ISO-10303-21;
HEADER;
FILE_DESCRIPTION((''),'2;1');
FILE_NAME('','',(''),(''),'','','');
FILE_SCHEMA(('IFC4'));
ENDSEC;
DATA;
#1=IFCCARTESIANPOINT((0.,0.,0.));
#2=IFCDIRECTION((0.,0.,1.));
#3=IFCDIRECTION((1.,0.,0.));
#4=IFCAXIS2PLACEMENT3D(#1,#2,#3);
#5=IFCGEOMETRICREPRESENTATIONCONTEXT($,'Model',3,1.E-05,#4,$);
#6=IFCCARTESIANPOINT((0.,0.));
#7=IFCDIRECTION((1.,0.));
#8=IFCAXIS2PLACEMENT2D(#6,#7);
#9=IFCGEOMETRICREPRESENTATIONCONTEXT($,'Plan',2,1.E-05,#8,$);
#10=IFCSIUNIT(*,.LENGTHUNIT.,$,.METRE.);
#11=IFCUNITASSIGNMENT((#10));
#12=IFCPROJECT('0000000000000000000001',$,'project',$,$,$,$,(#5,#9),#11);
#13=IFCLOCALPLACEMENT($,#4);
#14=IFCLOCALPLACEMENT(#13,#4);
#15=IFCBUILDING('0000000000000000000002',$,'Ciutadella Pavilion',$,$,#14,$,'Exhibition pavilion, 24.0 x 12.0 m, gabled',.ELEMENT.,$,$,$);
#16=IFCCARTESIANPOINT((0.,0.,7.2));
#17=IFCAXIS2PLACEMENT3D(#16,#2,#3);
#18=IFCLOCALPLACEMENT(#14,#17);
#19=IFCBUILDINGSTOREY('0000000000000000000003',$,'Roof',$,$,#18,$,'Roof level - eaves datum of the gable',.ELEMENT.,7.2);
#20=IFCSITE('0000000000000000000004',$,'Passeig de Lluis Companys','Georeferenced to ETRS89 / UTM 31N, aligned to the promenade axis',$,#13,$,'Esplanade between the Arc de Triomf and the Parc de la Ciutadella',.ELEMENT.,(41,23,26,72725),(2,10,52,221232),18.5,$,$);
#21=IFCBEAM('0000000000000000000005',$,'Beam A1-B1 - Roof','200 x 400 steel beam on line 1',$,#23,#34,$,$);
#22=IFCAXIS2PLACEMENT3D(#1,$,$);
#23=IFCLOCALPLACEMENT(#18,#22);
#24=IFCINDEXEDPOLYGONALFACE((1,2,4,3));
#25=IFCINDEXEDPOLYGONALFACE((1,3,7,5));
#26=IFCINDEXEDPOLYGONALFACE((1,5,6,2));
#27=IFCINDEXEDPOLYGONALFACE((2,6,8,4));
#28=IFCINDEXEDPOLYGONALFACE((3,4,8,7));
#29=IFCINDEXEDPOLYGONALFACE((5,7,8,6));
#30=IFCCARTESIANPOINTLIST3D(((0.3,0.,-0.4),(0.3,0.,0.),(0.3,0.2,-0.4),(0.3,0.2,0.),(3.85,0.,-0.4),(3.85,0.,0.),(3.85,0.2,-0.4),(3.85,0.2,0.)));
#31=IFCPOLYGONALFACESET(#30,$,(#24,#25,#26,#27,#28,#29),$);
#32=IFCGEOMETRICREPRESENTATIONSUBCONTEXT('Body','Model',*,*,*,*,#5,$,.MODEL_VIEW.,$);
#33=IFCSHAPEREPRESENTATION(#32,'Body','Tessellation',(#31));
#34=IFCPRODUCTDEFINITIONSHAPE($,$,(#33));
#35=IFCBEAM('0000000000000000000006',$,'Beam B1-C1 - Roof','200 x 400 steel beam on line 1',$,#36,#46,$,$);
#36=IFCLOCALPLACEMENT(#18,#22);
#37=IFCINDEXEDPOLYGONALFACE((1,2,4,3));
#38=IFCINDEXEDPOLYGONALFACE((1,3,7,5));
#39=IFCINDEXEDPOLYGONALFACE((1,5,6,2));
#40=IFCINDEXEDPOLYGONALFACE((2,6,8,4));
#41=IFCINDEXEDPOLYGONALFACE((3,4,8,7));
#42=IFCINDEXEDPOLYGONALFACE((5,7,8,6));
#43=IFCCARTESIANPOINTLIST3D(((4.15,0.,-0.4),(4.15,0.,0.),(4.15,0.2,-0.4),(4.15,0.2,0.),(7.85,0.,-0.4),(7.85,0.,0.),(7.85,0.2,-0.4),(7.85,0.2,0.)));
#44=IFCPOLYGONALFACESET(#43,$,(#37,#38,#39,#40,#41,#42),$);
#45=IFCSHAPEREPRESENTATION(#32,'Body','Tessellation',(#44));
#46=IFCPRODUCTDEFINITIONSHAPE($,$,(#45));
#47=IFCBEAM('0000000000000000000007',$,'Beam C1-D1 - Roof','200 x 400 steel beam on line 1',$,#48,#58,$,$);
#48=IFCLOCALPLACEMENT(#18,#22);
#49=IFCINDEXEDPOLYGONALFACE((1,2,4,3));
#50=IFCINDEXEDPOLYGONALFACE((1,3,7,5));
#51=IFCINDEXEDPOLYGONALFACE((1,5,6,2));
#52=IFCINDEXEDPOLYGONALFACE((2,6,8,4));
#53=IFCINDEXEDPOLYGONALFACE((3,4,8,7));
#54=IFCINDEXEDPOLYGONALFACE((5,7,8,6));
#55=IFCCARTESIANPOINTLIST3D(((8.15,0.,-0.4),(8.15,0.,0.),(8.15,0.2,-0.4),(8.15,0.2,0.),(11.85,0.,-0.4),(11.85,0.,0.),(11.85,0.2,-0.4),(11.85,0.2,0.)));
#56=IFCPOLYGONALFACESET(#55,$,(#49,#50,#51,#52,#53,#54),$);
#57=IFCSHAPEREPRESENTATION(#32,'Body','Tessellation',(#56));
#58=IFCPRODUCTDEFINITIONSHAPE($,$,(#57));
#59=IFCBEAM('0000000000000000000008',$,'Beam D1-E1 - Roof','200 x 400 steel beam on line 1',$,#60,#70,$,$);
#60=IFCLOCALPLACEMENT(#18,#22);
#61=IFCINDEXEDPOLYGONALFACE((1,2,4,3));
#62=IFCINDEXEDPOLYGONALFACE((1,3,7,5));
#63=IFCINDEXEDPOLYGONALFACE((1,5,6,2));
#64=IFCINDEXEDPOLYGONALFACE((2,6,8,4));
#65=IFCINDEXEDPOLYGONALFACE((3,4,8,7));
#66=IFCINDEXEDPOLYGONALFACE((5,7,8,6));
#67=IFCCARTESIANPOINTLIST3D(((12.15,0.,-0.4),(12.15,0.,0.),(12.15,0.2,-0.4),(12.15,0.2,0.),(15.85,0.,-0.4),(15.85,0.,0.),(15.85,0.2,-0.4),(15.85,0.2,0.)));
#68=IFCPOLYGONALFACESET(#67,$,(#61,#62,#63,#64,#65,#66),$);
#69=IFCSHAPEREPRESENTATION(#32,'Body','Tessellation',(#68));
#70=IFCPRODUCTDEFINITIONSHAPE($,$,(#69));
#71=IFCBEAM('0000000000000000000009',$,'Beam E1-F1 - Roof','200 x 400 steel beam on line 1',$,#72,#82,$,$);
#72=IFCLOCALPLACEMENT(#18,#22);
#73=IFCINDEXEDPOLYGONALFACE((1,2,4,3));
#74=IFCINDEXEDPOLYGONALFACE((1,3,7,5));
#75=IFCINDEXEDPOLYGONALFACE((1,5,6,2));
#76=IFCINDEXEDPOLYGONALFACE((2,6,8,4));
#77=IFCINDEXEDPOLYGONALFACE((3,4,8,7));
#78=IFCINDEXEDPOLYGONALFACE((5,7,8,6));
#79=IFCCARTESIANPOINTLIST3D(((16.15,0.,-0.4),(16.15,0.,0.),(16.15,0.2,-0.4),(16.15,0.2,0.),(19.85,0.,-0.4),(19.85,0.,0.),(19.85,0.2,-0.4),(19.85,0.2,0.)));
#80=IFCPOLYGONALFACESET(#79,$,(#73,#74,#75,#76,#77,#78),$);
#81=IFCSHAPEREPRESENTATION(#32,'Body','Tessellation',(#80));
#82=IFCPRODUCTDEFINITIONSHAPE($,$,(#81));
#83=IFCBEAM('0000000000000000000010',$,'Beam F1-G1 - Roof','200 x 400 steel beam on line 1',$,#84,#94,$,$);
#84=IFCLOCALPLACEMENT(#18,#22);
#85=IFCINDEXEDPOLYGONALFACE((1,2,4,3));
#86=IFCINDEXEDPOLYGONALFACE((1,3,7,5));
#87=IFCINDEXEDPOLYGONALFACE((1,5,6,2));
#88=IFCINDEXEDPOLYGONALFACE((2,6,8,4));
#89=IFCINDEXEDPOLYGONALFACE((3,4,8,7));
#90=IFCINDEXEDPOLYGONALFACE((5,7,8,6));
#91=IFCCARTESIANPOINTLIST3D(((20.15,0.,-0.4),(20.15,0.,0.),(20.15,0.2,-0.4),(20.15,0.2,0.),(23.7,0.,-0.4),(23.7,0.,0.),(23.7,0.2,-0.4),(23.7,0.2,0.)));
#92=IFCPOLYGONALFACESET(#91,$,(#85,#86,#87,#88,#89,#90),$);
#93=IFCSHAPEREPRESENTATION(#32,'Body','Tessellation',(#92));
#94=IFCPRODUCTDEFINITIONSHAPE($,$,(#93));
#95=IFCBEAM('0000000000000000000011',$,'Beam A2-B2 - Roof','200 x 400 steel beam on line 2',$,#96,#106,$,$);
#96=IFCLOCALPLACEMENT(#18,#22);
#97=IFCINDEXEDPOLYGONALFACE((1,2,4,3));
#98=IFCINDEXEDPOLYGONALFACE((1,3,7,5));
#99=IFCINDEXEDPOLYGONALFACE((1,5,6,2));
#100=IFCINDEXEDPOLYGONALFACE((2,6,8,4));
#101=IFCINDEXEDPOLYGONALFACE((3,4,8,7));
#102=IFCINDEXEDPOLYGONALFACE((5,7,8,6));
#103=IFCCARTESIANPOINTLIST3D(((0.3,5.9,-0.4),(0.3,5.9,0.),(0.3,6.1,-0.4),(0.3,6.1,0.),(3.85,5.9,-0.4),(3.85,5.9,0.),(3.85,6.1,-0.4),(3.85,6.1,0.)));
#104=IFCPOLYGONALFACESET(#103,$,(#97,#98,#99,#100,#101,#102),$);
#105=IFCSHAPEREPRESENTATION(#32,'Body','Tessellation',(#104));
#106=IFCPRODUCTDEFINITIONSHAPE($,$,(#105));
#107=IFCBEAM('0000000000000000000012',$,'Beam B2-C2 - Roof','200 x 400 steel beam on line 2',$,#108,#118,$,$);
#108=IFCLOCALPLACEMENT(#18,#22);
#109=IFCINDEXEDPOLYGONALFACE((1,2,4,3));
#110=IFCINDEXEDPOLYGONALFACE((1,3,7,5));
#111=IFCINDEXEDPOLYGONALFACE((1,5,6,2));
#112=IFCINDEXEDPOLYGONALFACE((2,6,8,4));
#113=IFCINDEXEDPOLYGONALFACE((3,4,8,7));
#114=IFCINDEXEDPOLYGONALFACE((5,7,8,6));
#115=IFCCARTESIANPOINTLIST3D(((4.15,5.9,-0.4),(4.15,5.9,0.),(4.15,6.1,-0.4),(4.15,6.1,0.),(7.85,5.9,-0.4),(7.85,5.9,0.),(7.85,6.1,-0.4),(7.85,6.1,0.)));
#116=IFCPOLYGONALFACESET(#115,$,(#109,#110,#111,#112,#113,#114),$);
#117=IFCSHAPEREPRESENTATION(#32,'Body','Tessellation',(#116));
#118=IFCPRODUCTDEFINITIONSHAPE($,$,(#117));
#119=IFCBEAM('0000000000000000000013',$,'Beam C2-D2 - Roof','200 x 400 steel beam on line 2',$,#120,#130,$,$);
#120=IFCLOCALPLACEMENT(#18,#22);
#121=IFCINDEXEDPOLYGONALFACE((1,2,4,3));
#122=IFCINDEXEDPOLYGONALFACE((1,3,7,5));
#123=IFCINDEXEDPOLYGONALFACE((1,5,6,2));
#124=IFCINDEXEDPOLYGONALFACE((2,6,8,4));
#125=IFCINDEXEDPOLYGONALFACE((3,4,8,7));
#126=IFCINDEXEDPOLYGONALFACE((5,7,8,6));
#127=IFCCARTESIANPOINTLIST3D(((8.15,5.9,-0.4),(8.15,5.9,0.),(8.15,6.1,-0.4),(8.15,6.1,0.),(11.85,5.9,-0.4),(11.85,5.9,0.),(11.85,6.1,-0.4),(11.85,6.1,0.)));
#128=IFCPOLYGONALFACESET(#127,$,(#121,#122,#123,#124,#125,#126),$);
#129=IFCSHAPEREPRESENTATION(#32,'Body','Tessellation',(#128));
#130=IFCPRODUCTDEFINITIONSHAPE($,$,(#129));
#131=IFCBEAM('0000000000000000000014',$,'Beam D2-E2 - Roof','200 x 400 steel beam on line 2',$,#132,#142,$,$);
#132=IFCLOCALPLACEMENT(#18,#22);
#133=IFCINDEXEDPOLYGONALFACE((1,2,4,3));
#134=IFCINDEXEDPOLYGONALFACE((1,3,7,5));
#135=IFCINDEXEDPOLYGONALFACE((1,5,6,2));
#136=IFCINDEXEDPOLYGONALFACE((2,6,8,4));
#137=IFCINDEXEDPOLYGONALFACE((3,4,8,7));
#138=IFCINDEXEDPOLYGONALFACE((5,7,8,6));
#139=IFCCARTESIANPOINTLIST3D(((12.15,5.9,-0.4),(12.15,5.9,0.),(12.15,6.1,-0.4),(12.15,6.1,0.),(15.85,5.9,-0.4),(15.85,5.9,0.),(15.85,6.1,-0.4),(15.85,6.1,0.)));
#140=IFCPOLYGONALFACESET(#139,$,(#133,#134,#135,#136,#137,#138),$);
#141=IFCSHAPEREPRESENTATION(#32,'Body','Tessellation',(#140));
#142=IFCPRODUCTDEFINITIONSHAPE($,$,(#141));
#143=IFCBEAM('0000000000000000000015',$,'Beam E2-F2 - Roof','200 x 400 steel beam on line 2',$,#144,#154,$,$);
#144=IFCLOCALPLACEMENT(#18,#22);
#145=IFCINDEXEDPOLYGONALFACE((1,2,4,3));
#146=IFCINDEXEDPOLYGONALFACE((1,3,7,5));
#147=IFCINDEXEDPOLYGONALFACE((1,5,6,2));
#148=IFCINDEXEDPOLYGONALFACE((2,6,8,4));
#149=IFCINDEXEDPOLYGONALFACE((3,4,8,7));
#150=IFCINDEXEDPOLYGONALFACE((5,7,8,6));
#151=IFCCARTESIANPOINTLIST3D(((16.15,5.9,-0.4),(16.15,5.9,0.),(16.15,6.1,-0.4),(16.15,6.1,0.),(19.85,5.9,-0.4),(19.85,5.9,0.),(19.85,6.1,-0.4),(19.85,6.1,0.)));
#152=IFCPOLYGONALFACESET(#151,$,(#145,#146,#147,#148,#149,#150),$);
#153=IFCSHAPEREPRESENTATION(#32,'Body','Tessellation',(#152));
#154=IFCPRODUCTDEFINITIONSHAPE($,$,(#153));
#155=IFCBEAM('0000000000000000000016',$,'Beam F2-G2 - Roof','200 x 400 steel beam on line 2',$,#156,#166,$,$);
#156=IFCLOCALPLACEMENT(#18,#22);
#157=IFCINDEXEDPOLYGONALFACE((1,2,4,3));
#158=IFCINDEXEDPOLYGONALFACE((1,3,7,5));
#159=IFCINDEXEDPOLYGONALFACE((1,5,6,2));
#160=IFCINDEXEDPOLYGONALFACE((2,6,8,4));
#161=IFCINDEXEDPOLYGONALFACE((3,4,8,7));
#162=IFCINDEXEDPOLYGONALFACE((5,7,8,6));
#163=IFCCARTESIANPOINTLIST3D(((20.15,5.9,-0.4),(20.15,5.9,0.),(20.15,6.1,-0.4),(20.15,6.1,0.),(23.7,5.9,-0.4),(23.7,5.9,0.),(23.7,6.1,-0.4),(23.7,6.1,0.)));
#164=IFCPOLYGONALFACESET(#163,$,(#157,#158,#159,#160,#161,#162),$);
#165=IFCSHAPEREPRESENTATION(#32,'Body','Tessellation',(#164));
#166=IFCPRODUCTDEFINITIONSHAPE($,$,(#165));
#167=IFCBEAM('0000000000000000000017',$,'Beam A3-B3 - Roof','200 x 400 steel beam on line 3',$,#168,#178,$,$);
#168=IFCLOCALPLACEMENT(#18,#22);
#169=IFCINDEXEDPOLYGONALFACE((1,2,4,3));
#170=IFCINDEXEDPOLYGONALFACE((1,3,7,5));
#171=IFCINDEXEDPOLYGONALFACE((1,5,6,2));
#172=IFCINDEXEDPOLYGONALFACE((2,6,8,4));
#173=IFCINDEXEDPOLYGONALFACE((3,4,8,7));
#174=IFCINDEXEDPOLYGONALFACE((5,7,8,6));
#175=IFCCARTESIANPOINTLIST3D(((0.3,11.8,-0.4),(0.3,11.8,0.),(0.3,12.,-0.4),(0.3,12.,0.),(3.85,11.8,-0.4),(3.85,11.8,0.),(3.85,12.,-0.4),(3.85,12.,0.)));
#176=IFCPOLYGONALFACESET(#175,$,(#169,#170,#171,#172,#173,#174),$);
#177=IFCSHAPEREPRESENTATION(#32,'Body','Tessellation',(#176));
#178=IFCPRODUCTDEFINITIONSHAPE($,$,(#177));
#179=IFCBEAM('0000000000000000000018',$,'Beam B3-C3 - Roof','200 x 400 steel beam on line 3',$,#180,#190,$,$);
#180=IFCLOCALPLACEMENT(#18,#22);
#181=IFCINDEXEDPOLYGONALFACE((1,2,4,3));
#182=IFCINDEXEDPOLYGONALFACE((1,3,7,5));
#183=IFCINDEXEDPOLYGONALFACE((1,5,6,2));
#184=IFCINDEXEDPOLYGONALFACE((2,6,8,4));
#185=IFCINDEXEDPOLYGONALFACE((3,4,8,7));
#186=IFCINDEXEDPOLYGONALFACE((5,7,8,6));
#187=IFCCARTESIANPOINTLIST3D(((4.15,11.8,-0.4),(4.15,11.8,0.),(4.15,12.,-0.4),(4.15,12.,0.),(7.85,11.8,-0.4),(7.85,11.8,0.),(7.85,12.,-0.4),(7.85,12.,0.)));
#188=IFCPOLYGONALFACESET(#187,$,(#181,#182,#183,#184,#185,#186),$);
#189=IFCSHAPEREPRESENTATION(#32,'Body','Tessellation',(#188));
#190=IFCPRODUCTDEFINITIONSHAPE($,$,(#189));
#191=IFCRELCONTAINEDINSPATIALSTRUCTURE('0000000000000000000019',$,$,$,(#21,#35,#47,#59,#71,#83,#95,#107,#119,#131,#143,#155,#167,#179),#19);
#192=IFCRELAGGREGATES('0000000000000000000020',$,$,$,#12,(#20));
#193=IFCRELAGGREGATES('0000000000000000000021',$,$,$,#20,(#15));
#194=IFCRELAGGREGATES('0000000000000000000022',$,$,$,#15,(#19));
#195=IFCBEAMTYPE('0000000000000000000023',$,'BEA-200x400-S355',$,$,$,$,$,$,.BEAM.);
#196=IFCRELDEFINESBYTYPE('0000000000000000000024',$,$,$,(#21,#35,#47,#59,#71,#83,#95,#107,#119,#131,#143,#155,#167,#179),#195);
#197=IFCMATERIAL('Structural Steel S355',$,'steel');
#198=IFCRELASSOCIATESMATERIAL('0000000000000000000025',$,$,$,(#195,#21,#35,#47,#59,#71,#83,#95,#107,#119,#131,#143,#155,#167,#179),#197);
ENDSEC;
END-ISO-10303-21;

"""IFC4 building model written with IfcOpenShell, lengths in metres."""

from ifc_helpers import new_model, si_unit, frame, origin_with_axes, origin_2d_with_axis, place, context, subcontext, project, spatial, line, indexed_curve, rectangle, outline, extrude, material, material_profile, profile_set, profile_usage, type_object, element, save


model = new_model("IFC4")

# Units and contexts
model_context = context("Model", 3, precision=1e-05, world=origin_with_axes())
plan_context = context("Plan", 2, precision=1e-05, world=origin_2d_with_axis())
body_context = subcontext(model_context, "Body", "Model", "MODEL_VIEW")
ifc_project = project(units=[si_unit("LENGTHUNIT", "METRE")], contexts=[model_context, plan_context])

# Site, building, storey
site_placement = place(None, origin_with_axes())
site = spatial("IfcSite", under=ifc_project, at=site_placement, Name="Passeig de Lluis Companys", Description="Georeferenced to ETRS89 / UTM 31N, aligned to the promenade axis", LongName="Esplanade between the Arc de Triomf and the Parc de la Ciutadella", CompositionType="ELEMENT", RefLatitude=(41, 23, 26, 72725), RefLongitude=(2, 10, 52, 221232), RefElevation=18.5)
building_placement = place(site_placement, origin_with_axes())
building = spatial("IfcBuilding", under=site, at=building_placement, Name="Ciutadella Pavilion", LongName="Exhibition pavilion, 24.0 x 12.0 m, gabled", CompositionType="ELEMENT")
storey_placement = place(building_placement, frame((0.0, 0.0, 7.2), z_axis=(0.0, 0.0, 1.0), x_axis=(1.0, 0.0, 0.0)))
storey = spatial("IfcBuildingStorey", under=building, at=storey_placement, Name="Roof", LongName="Roof level - eaves datum of the gable", CompositionType="ELEMENT", Elevation=7.2)

# Beams
ifc_material_1 = material(Name="Structural Steel S355", Category="steel")
ifc_material_profile = material_profile(ifc_material_1, rectangle(XDim=0.2, YDim=0.4))
ifc_profile_set = profile_set([ifc_material_profile], Name="BEA-200x400-S355")
ifc_profile_usage_1 = profile_usage(ifc_profile_set)
beam_type = type_object("IfcBeamType", Name="BEA-200x400-S355", PredefinedType="BEAM", material=ifc_profile_set)
beam_1_placement = place(storey_placement, frame((0.3, 0.0, -0.4), z_axis=(1.0, 0.0, 0.0), x_axis=(0.0, 1.0, 0.0)))
element("IfcBeam", 1, at=beam_1_placement, inside=storey, type_object=beam_type, material=ifc_profile_usage_1, Name="Beam A1-B1 - Roof", Description="200 x 400 steel beam on line 1", context=body_context, shape_type="SweptSolid", body=[
    extrude(outline(indexed_curve([(0.0, 0.0), (0.2, 0.0), (0.2, 0.4), (0.0, 0.4)], segments=[line(1, 2, 3, 4, 1)])), origin_with_axes(), (0.0, 0.0, 1.0), 3.55),
])
ifc_profile_usage_2 = profile_usage(ifc_profile_set)
beam_2_placement = place(storey_placement, frame((4.15, 0.0, -0.4), z_axis=(1.0, 0.0, 0.0), x_axis=(0.0, 1.0, 0.0)))
element("IfcBeam", 2, at=beam_2_placement, inside=storey, type_object=beam_type, material=ifc_profile_usage_2, Name="Beam B1-C1 - Roof", Description="200 x 400 steel beam on line 1", context=body_context, shape_type="SweptSolid", body=[
    extrude(outline(indexed_curve([(0.0, 0.0), (0.2, 0.0), (0.2, 0.4), (0.0, 0.4)], segments=[line(1, 2, 3, 4, 1)])), origin_with_axes(), (0.0, 0.0, 1.0), 3.7),
])
ifc_profile_usage_3 = profile_usage(ifc_profile_set)
beam_3_placement = place(storey_placement, frame((8.15, 0.0, -0.4), z_axis=(1.0, 0.0, 0.0), x_axis=(0.0, 1.0, 0.0)))
element("IfcBeam", 3, at=beam_3_placement, inside=storey, type_object=beam_type, material=ifc_profile_usage_3, Name="Beam C1-D1 - Roof", Description="200 x 400 steel beam on line 1", context=body_context, shape_type="SweptSolid", body=[
    extrude(outline(indexed_curve([(0.0, 0.0), (0.2, 0.0), (0.2, 0.4), (0.0, 0.4)], segments=[line(1, 2, 3, 4, 1)])), origin_with_axes(), (0.0, 0.0, 1.0), 3.7),
])
ifc_profile_usage_4 = profile_usage(ifc_profile_set)
beam_4_placement = place(storey_placement, frame((12.15, 0.0, -0.4), z_axis=(1.0, 0.0, 0.0), x_axis=(0.0, 1.0, 0.0)))
element("IfcBeam", 4, at=beam_4_placement, inside=storey, type_object=beam_type, material=ifc_profile_usage_4, Name="Beam D1-E1 - Roof", Description="200 x 400 steel beam on line 1", context=body_context, shape_type="SweptSolid", body=[
    extrude(outline(indexed_curve([(0.0, 0.0), (0.2, 0.0), (0.2, 0.4), (0.0, 0.4)], segments=[line(1, 2, 3, 4, 1)])), origin_with_axes(), (0.0, 0.0, 1.0), 3.7),
])
ifc_profile_usage_5 = profile_usage(ifc_profile_set)
beam_5_placement = place(storey_placement, frame((16.15, 0.0, -0.4), z_axis=(1.0, 0.0, 0.0), x_axis=(0.0, 1.0, 0.0)))
element("IfcBeam", 5, at=beam_5_placement, inside=storey, type_object=beam_type, material=ifc_profile_usage_5, Name="Beam E1-F1 - Roof", Description="200 x 400 steel beam on line 1", context=body_context, shape_type="SweptSolid", body=[
    extrude(outline(indexed_curve([(0.0, 0.0), (0.2, 0.0), (0.2, 0.4), (0.0, 0.4)], segments=[line(1, 2, 3, 4, 1)])), origin_with_axes(), (0.0, 0.0, 1.0), 3.7),
])
ifc_profile_usage_6 = profile_usage(ifc_profile_set)
beam_6_placement = place(storey_placement, frame((20.15, 0.0, -0.4), z_axis=(1.0, 0.0, 0.0), x_axis=(0.0, 1.0, 0.0)))
element("IfcBeam", 6, at=beam_6_placement, inside=storey, type_object=beam_type, material=ifc_profile_usage_6, Name="Beam F1-G1 - Roof", Description="200 x 400 steel beam on line 1", context=body_context, shape_type="SweptSolid", body=[
    extrude(outline(indexed_curve([(0.0, 0.0), (0.2, 0.0), (0.2, 0.4), (0.0, 0.4)], segments=[line(1, 2, 3, 4, 1)])), origin_with_axes(), (0.0, 0.0, 1.0), 3.55),
])
ifc_profile_usage_7 = profile_usage(ifc_profile_set)
beam_7_placement = place(storey_placement, frame((0.3, 5.9, -0.4), z_axis=(1.0, 0.0, 0.0), x_axis=(0.0, 1.0, 0.0)))
element("IfcBeam", 7, at=beam_7_placement, inside=storey, type_object=beam_type, material=ifc_profile_usage_7, Name="Beam A2-B2 - Roof", Description="200 x 400 steel beam on line 2", context=body_context, shape_type="SweptSolid", body=[
    extrude(outline(indexed_curve([(0.0, 0.0), (0.2, 0.0), (0.2, 0.4), (0.0, 0.4)], segments=[line(1, 2, 3, 4, 1)])), origin_with_axes(), (0.0, 0.0, 1.0), 3.55),
])
ifc_profile_usage_8 = profile_usage(ifc_profile_set)
beam_8_placement = place(storey_placement, frame((4.15, 5.9, -0.4), z_axis=(1.0, 0.0, 0.0), x_axis=(0.0, 1.0, 0.0)))
element("IfcBeam", 8, at=beam_8_placement, inside=storey, type_object=beam_type, material=ifc_profile_usage_8, Name="Beam B2-C2 - Roof", Description="200 x 400 steel beam on line 2", context=body_context, shape_type="SweptSolid", body=[
    extrude(outline(indexed_curve([(0.0, 0.0), (0.2, 0.0), (0.2, 0.4), (0.0, 0.4)], segments=[line(1, 2, 3, 4, 1)])), origin_with_axes(), (0.0, 0.0, 1.0), 3.7),
])
ifc_profile_usage_9 = profile_usage(ifc_profile_set)
beam_9_placement = place(storey_placement, frame((8.15, 5.9, -0.4), z_axis=(1.0, 0.0, 0.0), x_axis=(0.0, 1.0, 0.0)))
element("IfcBeam", 9, at=beam_9_placement, inside=storey, type_object=beam_type, material=ifc_profile_usage_9, Name="Beam C2-D2 - Roof", Description="200 x 400 steel beam on line 2", context=body_context, shape_type="SweptSolid", body=[
    extrude(outline(indexed_curve([(0.0, 0.0), (0.2, 0.0), (0.2, 0.4), (0.0, 0.4)], segments=[line(1, 2, 3, 4, 1)])), origin_with_axes(), (0.0, 0.0, 1.0), 3.7),
])
ifc_profile_usage_10 = profile_usage(ifc_profile_set)
beam_10_placement = place(storey_placement, frame((12.15, 5.9, -0.4), z_axis=(1.0, 0.0, 0.0), x_axis=(0.0, 1.0, 0.0)))
element("IfcBeam", 10, at=beam_10_placement, inside=storey, type_object=beam_type, material=ifc_profile_usage_10, Name="Beam D2-E2 - Roof", Description="200 x 400 steel beam on line 2", context=body_context, shape_type="SweptSolid", body=[
    extrude(outline(indexed_curve([(0.0, 0.0), (0.2, 0.0), (0.2, 0.4), (0.0, 0.4)], segments=[line(1, 2, 3, 4, 1)])), origin_with_axes(), (0.0, 0.0, 1.0), 3.7),
])
ifc_profile_usage_11 = profile_usage(ifc_profile_set)
beam_11_placement = place(storey_placement, frame((16.15, 5.9, -0.4), z_axis=(1.0, 0.0, 0.0), x_axis=(0.0, 1.0, 0.0)))
element("IfcBeam", 11, at=beam_11_placement, inside=storey, type_object=beam_type, material=ifc_profile_usage_11, Name="Beam E2-F2 - Roof", Description="200 x 400 steel beam on line 2", context=body_context, shape_type="SweptSolid", body=[
    extrude(outline(indexed_curve([(0.0, 0.0), (0.2, 0.0), (0.2, 0.4), (0.0, 0.4)], segments=[line(1, 2, 3, 4, 1)])), origin_with_axes(), (0.0, 0.0, 1.0), 3.7),
])
ifc_profile_usage_12 = profile_usage(ifc_profile_set)
beam_12_placement = place(storey_placement, frame((20.15, 5.9, -0.4), z_axis=(1.0, 0.0, 0.0), x_axis=(0.0, 1.0, 0.0)))
element("IfcBeam", 12, at=beam_12_placement, inside=storey, type_object=beam_type, material=ifc_profile_usage_12, Name="Beam F2-G2 - Roof", Description="200 x 400 steel beam on line 2", context=body_context, shape_type="SweptSolid", body=[
    extrude(outline(indexed_curve([(0.0, 0.0), (0.2, 0.0), (0.2, 0.4), (0.0, 0.4)], segments=[line(1, 2, 3, 4, 1)])), origin_with_axes(), (0.0, 0.0, 1.0), 3.55),
])
ifc_profile_usage_13 = profile_usage(ifc_profile_set)
beam_13_placement = place(storey_placement, frame((0.3, 11.8, -0.4), z_axis=(1.0, 0.0, 0.0), x_axis=(0.0, 1.0, 0.0)))
element("IfcBeam", 13, at=beam_13_placement, inside=storey, type_object=beam_type, material=ifc_profile_usage_13, Name="Beam A3-B3 - Roof", Description="200 x 400 steel beam on line 3", context=body_context, shape_type="SweptSolid", body=[
    extrude(outline(indexed_curve([(0.0, 0.0), (0.2, 0.0), (0.2, 0.4), (0.0, 0.4)], segments=[line(1, 2, 3, 4, 1)])), origin_with_axes(), (0.0, 0.0, 1.0), 3.55),
])
ifc_profile_usage_14 = profile_usage(ifc_profile_set)
beam_14_placement = place(storey_placement, frame((4.15, 11.8, -0.4), z_axis=(1.0, 0.0, 0.0), x_axis=(0.0, 1.0, 0.0)))
element("IfcBeam", 14, at=beam_14_placement, inside=storey, type_object=beam_type, material=ifc_profile_usage_14, Name="Beam B3-C3 - Roof", Description="200 x 400 steel beam on line 3", context=body_context, shape_type="SweptSolid", body=[
    extrude(outline(indexed_curve([(0.0, 0.0), (0.2, 0.0), (0.2, 0.4), (0.0, 0.4)], segments=[line(1, 2, 3, 4, 1)])), origin_with_axes(), (0.0, 0.0, 1.0), 3.7),
])

save(model, "model.ifc")
